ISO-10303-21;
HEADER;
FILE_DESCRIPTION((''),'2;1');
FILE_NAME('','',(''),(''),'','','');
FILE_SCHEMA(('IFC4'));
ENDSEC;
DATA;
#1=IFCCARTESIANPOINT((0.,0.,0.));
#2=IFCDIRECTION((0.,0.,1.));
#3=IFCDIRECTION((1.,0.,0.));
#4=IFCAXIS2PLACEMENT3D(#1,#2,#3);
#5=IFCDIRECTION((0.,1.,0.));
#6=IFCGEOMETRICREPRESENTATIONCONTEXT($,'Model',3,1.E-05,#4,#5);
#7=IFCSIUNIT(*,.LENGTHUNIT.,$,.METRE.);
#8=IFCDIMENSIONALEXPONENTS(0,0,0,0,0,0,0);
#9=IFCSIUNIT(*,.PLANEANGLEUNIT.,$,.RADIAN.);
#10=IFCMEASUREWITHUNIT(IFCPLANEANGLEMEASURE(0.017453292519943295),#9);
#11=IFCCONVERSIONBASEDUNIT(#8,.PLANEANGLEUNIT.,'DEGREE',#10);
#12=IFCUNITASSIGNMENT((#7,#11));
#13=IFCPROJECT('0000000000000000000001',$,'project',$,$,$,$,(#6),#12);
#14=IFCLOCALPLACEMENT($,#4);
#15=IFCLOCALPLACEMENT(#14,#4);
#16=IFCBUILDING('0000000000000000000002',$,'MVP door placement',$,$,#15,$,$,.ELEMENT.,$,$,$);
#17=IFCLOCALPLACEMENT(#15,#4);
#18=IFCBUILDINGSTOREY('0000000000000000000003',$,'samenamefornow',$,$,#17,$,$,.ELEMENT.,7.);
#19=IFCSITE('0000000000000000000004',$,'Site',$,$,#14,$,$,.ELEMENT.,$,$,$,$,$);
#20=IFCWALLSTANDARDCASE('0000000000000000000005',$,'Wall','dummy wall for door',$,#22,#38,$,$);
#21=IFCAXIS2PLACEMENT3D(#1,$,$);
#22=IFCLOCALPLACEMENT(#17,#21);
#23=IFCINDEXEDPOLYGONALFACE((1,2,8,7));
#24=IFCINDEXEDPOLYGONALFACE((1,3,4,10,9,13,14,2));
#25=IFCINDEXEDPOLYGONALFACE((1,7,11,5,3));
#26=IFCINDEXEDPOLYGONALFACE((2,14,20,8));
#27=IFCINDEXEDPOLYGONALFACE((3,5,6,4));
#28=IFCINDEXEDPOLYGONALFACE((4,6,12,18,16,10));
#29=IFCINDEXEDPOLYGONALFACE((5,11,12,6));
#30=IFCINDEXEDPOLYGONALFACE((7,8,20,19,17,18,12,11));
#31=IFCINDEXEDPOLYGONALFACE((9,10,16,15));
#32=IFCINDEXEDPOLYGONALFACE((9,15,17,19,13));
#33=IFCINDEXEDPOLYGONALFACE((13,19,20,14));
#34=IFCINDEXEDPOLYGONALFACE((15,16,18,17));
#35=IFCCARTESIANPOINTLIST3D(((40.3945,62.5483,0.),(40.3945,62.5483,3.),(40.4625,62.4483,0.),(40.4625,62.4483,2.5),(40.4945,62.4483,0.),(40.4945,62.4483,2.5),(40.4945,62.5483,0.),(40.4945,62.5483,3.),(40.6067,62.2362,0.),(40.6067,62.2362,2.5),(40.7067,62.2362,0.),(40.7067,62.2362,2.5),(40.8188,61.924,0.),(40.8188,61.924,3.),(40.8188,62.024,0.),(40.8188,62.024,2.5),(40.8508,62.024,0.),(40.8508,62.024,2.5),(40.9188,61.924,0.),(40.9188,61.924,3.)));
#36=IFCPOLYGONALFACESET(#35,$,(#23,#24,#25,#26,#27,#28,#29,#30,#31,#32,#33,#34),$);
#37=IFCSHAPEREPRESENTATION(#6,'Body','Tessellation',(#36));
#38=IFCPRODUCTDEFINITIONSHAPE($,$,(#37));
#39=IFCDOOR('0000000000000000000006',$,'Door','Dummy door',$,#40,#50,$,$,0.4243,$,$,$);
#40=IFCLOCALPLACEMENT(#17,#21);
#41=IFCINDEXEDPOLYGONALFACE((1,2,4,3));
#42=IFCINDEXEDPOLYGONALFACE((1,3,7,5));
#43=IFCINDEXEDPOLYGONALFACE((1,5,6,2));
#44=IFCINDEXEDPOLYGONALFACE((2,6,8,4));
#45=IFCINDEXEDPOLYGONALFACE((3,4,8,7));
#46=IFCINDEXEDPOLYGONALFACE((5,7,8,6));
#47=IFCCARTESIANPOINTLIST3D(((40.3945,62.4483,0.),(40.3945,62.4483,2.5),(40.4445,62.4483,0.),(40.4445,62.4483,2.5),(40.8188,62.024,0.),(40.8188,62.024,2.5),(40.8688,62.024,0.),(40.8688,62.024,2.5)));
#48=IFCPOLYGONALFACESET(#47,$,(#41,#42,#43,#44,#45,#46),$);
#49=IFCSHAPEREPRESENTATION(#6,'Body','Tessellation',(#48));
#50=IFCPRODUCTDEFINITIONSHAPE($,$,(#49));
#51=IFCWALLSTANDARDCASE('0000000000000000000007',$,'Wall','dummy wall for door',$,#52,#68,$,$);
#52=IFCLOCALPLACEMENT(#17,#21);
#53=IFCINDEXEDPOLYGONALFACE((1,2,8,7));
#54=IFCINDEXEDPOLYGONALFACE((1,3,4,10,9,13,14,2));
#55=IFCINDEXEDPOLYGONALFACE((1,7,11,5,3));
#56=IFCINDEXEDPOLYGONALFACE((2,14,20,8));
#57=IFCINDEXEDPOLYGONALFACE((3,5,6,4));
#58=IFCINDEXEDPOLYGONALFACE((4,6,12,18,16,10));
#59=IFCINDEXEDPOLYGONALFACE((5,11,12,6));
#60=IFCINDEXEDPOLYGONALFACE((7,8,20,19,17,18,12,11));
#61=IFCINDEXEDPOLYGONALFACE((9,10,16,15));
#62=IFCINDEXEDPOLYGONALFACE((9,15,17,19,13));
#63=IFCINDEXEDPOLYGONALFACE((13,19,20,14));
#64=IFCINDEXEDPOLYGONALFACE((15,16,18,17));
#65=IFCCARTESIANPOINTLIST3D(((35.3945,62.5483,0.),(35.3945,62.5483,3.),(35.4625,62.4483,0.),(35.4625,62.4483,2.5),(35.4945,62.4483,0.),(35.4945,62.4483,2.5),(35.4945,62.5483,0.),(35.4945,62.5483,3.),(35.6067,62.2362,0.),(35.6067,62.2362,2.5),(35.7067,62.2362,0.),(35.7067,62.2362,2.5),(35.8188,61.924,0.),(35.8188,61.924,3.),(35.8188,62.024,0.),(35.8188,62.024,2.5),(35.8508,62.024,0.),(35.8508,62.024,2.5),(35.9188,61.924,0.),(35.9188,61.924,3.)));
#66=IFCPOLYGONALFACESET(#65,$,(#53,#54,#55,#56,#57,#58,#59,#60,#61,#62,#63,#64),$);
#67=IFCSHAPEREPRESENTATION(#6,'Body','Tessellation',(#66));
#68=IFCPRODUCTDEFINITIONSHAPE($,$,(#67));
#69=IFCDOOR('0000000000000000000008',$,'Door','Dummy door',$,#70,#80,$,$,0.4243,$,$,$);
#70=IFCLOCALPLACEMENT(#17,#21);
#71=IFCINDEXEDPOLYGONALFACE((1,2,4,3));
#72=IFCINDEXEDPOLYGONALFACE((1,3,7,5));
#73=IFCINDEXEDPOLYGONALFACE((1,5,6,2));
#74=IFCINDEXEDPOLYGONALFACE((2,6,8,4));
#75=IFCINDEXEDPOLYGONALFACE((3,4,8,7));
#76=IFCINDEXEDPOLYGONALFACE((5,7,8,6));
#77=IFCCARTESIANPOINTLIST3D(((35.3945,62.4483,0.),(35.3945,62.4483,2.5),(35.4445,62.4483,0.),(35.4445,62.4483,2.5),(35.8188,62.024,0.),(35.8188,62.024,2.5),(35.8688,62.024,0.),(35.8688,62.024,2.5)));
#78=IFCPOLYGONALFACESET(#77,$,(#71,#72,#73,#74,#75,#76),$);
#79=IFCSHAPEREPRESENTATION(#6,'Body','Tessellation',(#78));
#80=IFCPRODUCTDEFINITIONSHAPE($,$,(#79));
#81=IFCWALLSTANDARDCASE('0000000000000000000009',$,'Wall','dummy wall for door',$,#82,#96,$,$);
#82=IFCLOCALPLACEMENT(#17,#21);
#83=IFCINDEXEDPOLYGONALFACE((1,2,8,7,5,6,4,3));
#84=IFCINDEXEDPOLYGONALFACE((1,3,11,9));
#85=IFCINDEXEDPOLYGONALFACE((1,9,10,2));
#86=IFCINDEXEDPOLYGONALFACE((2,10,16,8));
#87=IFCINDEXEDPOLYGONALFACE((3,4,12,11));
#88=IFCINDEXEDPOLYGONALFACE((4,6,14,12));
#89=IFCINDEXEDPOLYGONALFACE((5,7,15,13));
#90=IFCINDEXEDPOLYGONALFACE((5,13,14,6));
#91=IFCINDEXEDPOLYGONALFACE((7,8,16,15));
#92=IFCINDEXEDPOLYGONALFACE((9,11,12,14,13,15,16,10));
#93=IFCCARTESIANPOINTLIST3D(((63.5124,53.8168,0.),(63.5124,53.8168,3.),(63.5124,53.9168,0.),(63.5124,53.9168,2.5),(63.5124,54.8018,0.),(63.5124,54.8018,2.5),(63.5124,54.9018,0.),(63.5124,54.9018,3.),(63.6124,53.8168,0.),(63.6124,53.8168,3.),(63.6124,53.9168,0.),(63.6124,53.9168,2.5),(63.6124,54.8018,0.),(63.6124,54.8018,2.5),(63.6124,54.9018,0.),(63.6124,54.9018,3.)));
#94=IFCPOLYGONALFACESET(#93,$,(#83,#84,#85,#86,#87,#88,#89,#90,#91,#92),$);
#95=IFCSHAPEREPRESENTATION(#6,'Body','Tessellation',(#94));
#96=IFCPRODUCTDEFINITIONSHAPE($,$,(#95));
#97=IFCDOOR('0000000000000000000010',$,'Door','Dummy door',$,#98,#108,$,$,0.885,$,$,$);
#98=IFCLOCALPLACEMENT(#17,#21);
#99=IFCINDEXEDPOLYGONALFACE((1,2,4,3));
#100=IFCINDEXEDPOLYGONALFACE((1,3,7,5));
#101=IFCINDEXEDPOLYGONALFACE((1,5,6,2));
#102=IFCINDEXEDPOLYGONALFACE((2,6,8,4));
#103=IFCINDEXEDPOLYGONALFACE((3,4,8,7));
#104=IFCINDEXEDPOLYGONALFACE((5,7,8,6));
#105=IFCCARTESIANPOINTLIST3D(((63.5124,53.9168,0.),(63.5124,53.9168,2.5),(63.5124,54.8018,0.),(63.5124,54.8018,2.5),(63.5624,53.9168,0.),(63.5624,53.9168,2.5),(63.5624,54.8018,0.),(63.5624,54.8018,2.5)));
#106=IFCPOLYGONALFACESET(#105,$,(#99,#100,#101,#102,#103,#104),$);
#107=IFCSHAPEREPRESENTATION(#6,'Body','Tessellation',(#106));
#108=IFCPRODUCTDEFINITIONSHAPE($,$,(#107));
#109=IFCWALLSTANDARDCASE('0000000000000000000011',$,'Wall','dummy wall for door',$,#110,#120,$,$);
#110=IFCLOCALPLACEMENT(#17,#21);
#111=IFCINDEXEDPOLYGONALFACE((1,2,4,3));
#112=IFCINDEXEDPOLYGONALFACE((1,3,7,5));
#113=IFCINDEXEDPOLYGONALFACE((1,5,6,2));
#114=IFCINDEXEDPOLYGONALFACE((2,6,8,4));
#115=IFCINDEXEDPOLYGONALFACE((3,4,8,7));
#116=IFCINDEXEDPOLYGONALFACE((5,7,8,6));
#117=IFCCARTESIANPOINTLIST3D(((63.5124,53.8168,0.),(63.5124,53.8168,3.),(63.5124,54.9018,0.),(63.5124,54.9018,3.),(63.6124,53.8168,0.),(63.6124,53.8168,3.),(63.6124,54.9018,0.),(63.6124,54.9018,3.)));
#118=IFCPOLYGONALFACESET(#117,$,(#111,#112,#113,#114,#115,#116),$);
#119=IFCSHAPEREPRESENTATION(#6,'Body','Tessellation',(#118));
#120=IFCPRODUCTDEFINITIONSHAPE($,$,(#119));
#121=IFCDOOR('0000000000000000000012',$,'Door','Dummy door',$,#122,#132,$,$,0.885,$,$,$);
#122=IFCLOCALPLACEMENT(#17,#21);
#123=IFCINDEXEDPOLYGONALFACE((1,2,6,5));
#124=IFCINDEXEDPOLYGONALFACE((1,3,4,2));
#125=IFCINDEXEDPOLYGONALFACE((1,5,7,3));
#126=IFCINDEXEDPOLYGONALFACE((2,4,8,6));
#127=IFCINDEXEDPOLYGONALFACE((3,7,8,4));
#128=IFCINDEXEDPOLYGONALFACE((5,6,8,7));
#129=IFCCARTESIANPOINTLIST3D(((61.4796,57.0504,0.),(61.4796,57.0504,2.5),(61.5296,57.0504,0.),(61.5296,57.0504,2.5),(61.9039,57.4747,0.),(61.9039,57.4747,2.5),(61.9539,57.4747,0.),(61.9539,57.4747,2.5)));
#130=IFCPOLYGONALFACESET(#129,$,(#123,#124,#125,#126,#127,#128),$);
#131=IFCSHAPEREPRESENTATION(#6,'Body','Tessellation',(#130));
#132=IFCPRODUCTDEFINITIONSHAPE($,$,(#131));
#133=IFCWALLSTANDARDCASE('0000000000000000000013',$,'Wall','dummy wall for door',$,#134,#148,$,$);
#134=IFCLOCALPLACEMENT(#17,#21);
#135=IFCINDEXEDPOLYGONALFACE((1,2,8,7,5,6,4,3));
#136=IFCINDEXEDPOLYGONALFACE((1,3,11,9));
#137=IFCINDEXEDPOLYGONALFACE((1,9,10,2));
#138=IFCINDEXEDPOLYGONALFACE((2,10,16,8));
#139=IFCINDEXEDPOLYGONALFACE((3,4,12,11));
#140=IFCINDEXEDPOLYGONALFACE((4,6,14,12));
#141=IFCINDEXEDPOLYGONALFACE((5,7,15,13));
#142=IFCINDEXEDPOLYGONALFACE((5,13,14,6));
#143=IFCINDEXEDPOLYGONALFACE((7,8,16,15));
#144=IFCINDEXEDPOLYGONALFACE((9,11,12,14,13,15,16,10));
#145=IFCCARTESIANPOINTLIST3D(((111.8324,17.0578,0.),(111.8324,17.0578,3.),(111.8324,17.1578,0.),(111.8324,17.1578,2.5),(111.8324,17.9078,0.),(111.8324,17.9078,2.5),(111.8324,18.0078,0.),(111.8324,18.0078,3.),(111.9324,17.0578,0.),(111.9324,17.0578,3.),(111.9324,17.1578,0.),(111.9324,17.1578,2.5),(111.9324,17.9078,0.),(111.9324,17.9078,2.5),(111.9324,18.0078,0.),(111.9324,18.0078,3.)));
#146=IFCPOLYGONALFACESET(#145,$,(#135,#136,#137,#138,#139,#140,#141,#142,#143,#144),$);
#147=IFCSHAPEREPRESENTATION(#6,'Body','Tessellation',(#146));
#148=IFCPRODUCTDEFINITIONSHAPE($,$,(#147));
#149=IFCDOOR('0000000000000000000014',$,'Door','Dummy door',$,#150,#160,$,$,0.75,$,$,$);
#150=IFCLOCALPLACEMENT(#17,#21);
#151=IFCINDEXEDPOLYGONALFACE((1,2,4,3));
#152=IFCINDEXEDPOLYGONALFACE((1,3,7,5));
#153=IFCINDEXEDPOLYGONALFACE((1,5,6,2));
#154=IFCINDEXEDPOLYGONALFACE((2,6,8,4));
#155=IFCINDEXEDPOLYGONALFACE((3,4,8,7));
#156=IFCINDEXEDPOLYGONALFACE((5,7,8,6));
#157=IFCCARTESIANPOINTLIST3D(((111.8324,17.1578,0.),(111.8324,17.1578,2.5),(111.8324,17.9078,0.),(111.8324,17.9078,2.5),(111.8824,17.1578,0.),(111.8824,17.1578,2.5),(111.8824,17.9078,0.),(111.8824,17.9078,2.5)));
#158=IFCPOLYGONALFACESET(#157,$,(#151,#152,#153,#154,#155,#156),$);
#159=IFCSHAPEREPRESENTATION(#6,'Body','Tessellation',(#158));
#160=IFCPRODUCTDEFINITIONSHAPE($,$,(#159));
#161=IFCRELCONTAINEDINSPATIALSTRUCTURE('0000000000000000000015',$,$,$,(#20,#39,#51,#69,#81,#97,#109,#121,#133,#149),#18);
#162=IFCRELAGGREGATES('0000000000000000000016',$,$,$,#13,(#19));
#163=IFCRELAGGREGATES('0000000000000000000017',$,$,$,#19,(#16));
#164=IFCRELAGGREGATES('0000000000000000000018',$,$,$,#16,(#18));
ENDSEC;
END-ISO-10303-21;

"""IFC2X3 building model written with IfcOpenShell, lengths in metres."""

from ifc_helpers import new_model, entity, si_unit, converted_unit, direction, origin_with_axes, place, context, project, spatial, polyline, outline, extrude, element, fill, save


model = new_model("IFC2X3")

# Units and contexts
model_context = context("Model", 3, precision=1e-05, world=origin_with_axes(), true_north=direction((0.0, 1.0, 0.0)))
ifc_project = project(units=[si_unit("LENGTHUNIT", "METRE"), converted_unit("PLANEANGLEUNIT", "DEGREE", entity("IfcPlaneAngleMeasure", 0.017453292519943295), si_unit("PLANEANGLEUNIT", "RADIAN"), dimensions=[0, 0, 0, 0, 0, 0, 0])], contexts=[model_context])

# Site, building, storey
site_placement = place(None, origin_with_axes())
site = spatial("IfcSite", under=ifc_project, at=site_placement, Name="Site", CompositionType="ELEMENT")
building_placement = place(site_placement, origin_with_axes())
building = spatial("IfcBuilding", under=site, at=building_placement, Name="MVP door placement", CompositionType="ELEMENT")
storey_placement = place(building_placement, origin_with_axes())
storey = spatial("IfcBuildingStorey", under=building, at=storey_placement, Name="samenamefornow", CompositionType="ELEMENT", Elevation=7.0)

# Walls, openings, doors
wall_1_placement = place(storey_placement, origin_with_axes())
wall_1 = element("IfcWallStandardCase", 1, at=wall_1_placement, inside=storey, Name="Wall", Description="dummy wall for door", context=model_context, shape_type="SweptSolid", body=[
    extrude(outline(polyline([(40.8188, 61.924, 0.0), (40.3945, 62.5483, 0.0), (40.4945, 62.5483, 0.0), (40.9188, 61.924, 0.0), (40.8188, 61.924, 0.0)])), origin_with_axes(), (0.0, 0.0, 1.0), 3.0),
])
opening_1_placement = place(wall_1_placement, origin_with_axes())
opening_1 = element("IfcOpeningElement", 2, at=opening_1_placement, cuts=wall_1, context=model_context, shape_type="SweptSolid", body=[
    extrude(outline(polyline([(40.8188, 62.024, 0.0), (40.3945, 62.4483, 0.0), (40.4945, 62.4483, 0.0), (40.9188, 62.024, 0.0), (40.8188, 62.024, 0.0)])), origin_with_axes(), (0.0, 0.0, 1.0), 2.5),
])
door_1_placement = place(opening_1_placement, origin_with_axes())
door_1 = element("IfcDoor", 3, at=door_1_placement, inside=storey, Name="Door", Description="Dummy door", OverallWidth=0.4243, context=model_context, shape_type="SweptSolid", body=[
    extrude(outline(polyline([(40.8188, 62.024, 0.0), (40.3945, 62.4483, 0.0), (40.4445, 62.4483, 0.0), (40.8688, 62.024, 0.0), (40.8188, 62.024, 0.0)])), origin_with_axes(), (0.0, 0.0, 1.0), 2.5),
])
fill(opening_1, door_1)
wall_2_placement = place(storey_placement, origin_with_axes())
wall_2 = element("IfcWallStandardCase", 4, at=wall_2_placement, inside=storey, Name="Wall", Description="dummy wall for door", context=model_context, shape_type="SweptSolid", body=[
    extrude(outline(polyline([(35.8188, 61.924, 0.0), (35.3945, 62.5483, 0.0), (35.4945, 62.5483, 0.0), (35.9188, 61.924, 0.0), (35.8188, 61.924, 0.0)])), origin_with_axes(), (0.0, 0.0, 1.0), 3.0),
])
opening_2_placement = place(wall_2_placement, origin_with_axes())
opening_2 = element("IfcOpeningElement", 5, at=opening_2_placement, cuts=wall_2, context=model_context, shape_type="SweptSolid", body=[
    extrude(outline(polyline([(35.8188, 62.024, 0.0), (35.3945, 62.4483, 0.0), (35.4945, 62.4483, 0.0), (35.9188, 62.024, 0.0), (35.8188, 62.024, 0.0)])), origin_with_axes(), (0.0, 0.0, 1.0), 2.5),
])
door_2_placement = place(opening_2_placement, origin_with_axes())
door_2 = element("IfcDoor", 6, at=door_2_placement, inside=storey, Name="Door", Description="Dummy door", OverallWidth=0.4243, context=model_context, shape_type="SweptSolid", body=[
    extrude(outline(polyline([(35.8188, 62.024, 0.0), (35.3945, 62.4483, 0.0), (35.4445, 62.4483, 0.0), (35.8688, 62.024, 0.0), (35.8188, 62.024, 0.0)])), origin_with_axes(), (0.0, 0.0, 1.0), 2.5),
])
fill(opening_2, door_2)
wall_3_placement = place(storey_placement, origin_with_axes())
wall_3 = element("IfcWallStandardCase", 7, at=wall_3_placement, inside=storey, Name="Wall", Description="dummy wall for door", context=model_context, shape_type="SweptSolid", body=[
    extrude(outline(polyline([(63.5124, 54.9018, 0.0), (63.5124, 53.8168, 0.0), (63.6124, 53.8168, 0.0), (63.6124, 54.9018, 0.0), (63.5124, 54.9018, 0.0)])), origin_with_axes(), (0.0, 0.0, 1.0), 3.0),
])
opening_3_placement = place(wall_3_placement, origin_with_axes())
opening_3 = element("IfcOpeningElement", 8, at=opening_3_placement, cuts=wall_3, context=model_context, shape_type="SweptSolid", body=[
    extrude(outline(polyline([(63.5124, 54.8018, 0.0), (63.5124, 53.9168, 0.0), (63.6124, 53.9168, 0.0), (63.6124, 54.8018, 0.0), (63.5124, 54.8018, 0.0)])), origin_with_axes(), (0.0, 0.0, 1.0), 2.5),
])
door_3_placement = place(opening_3_placement, origin_with_axes())
door_3 = element("IfcDoor", 9, at=door_3_placement, inside=storey, Name="Door", Description="Dummy door", OverallWidth=0.885, context=model_context, shape_type="SweptSolid", body=[
    extrude(outline(polyline([(63.5124, 54.8018, 0.0), (63.5124, 53.9168, 0.0), (63.5624, 53.9168, 0.0), (63.5624, 54.8018, 0.0), (63.5124, 54.8018, 0.0)])), origin_with_axes(), (0.0, 0.0, 1.0), 2.5),
])
fill(opening_3, door_3)
wall_4_placement = place(storey_placement, origin_with_axes())
wall_4 = element("IfcWallStandardCase", 10, at=wall_4_placement, inside=storey, Name="Wall", Description="dummy wall for door", context=model_context, shape_type="SweptSolid", body=[
    extrude(outline(polyline([(63.5124, 54.9018, 0.0), (63.5124, 53.8168, 0.0), (63.6124, 53.8168, 0.0), (63.6124, 54.9018, 0.0), (63.5124, 54.9018, 0.0)])), origin_with_axes(), (0.0, 0.0, 1.0), 3.0),
])
opening_4_placement = place(wall_4_placement, origin_with_axes())
opening_4 = element("IfcOpeningElement", 11, at=opening_4_placement, cuts=wall_4, context=model_context, shape_type="SweptSolid", body=[
    extrude(outline(polyline([(61.4796, 57.0504, 0.0), (61.9039, 57.4747, 0.0), (62.0039, 57.4747, 0.0), (61.5796, 57.0504, 0.0), (61.4796, 57.0504, 0.0)])), origin_with_axes(), (0.0, 0.0, 1.0), 2.5),
])
door_4_placement = place(opening_4_placement, origin_with_axes())
door_4 = element("IfcDoor", 12, at=door_4_placement, inside=storey, Name="Door", Description="Dummy door", OverallWidth=0.885, context=model_context, shape_type="SweptSolid", body=[
    extrude(outline(polyline([(61.4796, 57.0504, 0.0), (61.9039, 57.4747, 0.0), (61.9539, 57.4747, 0.0), (61.5296, 57.0504, 0.0), (61.4796, 57.0504, 0.0)])), origin_with_axes(), (0.0, 0.0, 1.0), 2.5),
])
fill(opening_4, door_4)
wall_5_placement = place(storey_placement, origin_with_axes())
wall_5 = element("IfcWallStandardCase", 13, at=wall_5_placement, inside=storey, Name="Wall", Description="dummy wall for door", context=model_context, shape_type="SweptSolid", body=[
    extrude(outline(polyline([(111.8324, 17.0578, 0.0), (111.8324, 18.0078, 0.0), (111.9324, 18.0078, 0.0), (111.9324, 17.0578, 0.0), (111.8324, 17.0578, 0.0)])), origin_with_axes(), (0.0, 0.0, 1.0), 3.0),
])
opening_5_placement = place(wall_5_placement, origin_with_axes())
opening_5 = element("IfcOpeningElement", 14, at=opening_5_placement, cuts=wall_5, context=model_context, shape_type="SweptSolid", body=[
    extrude(outline(polyline([(111.8324, 17.1578, 0.0), (111.8324, 17.9078, 0.0), (111.9324, 17.9078, 0.0), (111.9324, 17.1578, 0.0), (111.8324, 17.1578, 0.0)])), origin_with_axes(), (0.0, 0.0, 1.0), 2.5),
])
door_5_placement = place(opening_5_placement, origin_with_axes())
door_5 = element("IfcDoor", 15, at=door_5_placement, inside=storey, Name="Door", Description="Dummy door", OverallWidth=0.75, context=model_context, shape_type="SweptSolid", body=[
    extrude(outline(polyline([(111.8324, 17.1578, 0.0), (111.8324, 17.9078, 0.0), (111.8824, 17.9078, 0.0), (111.8824, 17.1578, 0.0), (111.8324, 17.1578, 0.0)])), origin_with_axes(), (0.0, 0.0, 1.0), 2.5),
])
fill(opening_5, door_5)

save(model, "model.ifc")
